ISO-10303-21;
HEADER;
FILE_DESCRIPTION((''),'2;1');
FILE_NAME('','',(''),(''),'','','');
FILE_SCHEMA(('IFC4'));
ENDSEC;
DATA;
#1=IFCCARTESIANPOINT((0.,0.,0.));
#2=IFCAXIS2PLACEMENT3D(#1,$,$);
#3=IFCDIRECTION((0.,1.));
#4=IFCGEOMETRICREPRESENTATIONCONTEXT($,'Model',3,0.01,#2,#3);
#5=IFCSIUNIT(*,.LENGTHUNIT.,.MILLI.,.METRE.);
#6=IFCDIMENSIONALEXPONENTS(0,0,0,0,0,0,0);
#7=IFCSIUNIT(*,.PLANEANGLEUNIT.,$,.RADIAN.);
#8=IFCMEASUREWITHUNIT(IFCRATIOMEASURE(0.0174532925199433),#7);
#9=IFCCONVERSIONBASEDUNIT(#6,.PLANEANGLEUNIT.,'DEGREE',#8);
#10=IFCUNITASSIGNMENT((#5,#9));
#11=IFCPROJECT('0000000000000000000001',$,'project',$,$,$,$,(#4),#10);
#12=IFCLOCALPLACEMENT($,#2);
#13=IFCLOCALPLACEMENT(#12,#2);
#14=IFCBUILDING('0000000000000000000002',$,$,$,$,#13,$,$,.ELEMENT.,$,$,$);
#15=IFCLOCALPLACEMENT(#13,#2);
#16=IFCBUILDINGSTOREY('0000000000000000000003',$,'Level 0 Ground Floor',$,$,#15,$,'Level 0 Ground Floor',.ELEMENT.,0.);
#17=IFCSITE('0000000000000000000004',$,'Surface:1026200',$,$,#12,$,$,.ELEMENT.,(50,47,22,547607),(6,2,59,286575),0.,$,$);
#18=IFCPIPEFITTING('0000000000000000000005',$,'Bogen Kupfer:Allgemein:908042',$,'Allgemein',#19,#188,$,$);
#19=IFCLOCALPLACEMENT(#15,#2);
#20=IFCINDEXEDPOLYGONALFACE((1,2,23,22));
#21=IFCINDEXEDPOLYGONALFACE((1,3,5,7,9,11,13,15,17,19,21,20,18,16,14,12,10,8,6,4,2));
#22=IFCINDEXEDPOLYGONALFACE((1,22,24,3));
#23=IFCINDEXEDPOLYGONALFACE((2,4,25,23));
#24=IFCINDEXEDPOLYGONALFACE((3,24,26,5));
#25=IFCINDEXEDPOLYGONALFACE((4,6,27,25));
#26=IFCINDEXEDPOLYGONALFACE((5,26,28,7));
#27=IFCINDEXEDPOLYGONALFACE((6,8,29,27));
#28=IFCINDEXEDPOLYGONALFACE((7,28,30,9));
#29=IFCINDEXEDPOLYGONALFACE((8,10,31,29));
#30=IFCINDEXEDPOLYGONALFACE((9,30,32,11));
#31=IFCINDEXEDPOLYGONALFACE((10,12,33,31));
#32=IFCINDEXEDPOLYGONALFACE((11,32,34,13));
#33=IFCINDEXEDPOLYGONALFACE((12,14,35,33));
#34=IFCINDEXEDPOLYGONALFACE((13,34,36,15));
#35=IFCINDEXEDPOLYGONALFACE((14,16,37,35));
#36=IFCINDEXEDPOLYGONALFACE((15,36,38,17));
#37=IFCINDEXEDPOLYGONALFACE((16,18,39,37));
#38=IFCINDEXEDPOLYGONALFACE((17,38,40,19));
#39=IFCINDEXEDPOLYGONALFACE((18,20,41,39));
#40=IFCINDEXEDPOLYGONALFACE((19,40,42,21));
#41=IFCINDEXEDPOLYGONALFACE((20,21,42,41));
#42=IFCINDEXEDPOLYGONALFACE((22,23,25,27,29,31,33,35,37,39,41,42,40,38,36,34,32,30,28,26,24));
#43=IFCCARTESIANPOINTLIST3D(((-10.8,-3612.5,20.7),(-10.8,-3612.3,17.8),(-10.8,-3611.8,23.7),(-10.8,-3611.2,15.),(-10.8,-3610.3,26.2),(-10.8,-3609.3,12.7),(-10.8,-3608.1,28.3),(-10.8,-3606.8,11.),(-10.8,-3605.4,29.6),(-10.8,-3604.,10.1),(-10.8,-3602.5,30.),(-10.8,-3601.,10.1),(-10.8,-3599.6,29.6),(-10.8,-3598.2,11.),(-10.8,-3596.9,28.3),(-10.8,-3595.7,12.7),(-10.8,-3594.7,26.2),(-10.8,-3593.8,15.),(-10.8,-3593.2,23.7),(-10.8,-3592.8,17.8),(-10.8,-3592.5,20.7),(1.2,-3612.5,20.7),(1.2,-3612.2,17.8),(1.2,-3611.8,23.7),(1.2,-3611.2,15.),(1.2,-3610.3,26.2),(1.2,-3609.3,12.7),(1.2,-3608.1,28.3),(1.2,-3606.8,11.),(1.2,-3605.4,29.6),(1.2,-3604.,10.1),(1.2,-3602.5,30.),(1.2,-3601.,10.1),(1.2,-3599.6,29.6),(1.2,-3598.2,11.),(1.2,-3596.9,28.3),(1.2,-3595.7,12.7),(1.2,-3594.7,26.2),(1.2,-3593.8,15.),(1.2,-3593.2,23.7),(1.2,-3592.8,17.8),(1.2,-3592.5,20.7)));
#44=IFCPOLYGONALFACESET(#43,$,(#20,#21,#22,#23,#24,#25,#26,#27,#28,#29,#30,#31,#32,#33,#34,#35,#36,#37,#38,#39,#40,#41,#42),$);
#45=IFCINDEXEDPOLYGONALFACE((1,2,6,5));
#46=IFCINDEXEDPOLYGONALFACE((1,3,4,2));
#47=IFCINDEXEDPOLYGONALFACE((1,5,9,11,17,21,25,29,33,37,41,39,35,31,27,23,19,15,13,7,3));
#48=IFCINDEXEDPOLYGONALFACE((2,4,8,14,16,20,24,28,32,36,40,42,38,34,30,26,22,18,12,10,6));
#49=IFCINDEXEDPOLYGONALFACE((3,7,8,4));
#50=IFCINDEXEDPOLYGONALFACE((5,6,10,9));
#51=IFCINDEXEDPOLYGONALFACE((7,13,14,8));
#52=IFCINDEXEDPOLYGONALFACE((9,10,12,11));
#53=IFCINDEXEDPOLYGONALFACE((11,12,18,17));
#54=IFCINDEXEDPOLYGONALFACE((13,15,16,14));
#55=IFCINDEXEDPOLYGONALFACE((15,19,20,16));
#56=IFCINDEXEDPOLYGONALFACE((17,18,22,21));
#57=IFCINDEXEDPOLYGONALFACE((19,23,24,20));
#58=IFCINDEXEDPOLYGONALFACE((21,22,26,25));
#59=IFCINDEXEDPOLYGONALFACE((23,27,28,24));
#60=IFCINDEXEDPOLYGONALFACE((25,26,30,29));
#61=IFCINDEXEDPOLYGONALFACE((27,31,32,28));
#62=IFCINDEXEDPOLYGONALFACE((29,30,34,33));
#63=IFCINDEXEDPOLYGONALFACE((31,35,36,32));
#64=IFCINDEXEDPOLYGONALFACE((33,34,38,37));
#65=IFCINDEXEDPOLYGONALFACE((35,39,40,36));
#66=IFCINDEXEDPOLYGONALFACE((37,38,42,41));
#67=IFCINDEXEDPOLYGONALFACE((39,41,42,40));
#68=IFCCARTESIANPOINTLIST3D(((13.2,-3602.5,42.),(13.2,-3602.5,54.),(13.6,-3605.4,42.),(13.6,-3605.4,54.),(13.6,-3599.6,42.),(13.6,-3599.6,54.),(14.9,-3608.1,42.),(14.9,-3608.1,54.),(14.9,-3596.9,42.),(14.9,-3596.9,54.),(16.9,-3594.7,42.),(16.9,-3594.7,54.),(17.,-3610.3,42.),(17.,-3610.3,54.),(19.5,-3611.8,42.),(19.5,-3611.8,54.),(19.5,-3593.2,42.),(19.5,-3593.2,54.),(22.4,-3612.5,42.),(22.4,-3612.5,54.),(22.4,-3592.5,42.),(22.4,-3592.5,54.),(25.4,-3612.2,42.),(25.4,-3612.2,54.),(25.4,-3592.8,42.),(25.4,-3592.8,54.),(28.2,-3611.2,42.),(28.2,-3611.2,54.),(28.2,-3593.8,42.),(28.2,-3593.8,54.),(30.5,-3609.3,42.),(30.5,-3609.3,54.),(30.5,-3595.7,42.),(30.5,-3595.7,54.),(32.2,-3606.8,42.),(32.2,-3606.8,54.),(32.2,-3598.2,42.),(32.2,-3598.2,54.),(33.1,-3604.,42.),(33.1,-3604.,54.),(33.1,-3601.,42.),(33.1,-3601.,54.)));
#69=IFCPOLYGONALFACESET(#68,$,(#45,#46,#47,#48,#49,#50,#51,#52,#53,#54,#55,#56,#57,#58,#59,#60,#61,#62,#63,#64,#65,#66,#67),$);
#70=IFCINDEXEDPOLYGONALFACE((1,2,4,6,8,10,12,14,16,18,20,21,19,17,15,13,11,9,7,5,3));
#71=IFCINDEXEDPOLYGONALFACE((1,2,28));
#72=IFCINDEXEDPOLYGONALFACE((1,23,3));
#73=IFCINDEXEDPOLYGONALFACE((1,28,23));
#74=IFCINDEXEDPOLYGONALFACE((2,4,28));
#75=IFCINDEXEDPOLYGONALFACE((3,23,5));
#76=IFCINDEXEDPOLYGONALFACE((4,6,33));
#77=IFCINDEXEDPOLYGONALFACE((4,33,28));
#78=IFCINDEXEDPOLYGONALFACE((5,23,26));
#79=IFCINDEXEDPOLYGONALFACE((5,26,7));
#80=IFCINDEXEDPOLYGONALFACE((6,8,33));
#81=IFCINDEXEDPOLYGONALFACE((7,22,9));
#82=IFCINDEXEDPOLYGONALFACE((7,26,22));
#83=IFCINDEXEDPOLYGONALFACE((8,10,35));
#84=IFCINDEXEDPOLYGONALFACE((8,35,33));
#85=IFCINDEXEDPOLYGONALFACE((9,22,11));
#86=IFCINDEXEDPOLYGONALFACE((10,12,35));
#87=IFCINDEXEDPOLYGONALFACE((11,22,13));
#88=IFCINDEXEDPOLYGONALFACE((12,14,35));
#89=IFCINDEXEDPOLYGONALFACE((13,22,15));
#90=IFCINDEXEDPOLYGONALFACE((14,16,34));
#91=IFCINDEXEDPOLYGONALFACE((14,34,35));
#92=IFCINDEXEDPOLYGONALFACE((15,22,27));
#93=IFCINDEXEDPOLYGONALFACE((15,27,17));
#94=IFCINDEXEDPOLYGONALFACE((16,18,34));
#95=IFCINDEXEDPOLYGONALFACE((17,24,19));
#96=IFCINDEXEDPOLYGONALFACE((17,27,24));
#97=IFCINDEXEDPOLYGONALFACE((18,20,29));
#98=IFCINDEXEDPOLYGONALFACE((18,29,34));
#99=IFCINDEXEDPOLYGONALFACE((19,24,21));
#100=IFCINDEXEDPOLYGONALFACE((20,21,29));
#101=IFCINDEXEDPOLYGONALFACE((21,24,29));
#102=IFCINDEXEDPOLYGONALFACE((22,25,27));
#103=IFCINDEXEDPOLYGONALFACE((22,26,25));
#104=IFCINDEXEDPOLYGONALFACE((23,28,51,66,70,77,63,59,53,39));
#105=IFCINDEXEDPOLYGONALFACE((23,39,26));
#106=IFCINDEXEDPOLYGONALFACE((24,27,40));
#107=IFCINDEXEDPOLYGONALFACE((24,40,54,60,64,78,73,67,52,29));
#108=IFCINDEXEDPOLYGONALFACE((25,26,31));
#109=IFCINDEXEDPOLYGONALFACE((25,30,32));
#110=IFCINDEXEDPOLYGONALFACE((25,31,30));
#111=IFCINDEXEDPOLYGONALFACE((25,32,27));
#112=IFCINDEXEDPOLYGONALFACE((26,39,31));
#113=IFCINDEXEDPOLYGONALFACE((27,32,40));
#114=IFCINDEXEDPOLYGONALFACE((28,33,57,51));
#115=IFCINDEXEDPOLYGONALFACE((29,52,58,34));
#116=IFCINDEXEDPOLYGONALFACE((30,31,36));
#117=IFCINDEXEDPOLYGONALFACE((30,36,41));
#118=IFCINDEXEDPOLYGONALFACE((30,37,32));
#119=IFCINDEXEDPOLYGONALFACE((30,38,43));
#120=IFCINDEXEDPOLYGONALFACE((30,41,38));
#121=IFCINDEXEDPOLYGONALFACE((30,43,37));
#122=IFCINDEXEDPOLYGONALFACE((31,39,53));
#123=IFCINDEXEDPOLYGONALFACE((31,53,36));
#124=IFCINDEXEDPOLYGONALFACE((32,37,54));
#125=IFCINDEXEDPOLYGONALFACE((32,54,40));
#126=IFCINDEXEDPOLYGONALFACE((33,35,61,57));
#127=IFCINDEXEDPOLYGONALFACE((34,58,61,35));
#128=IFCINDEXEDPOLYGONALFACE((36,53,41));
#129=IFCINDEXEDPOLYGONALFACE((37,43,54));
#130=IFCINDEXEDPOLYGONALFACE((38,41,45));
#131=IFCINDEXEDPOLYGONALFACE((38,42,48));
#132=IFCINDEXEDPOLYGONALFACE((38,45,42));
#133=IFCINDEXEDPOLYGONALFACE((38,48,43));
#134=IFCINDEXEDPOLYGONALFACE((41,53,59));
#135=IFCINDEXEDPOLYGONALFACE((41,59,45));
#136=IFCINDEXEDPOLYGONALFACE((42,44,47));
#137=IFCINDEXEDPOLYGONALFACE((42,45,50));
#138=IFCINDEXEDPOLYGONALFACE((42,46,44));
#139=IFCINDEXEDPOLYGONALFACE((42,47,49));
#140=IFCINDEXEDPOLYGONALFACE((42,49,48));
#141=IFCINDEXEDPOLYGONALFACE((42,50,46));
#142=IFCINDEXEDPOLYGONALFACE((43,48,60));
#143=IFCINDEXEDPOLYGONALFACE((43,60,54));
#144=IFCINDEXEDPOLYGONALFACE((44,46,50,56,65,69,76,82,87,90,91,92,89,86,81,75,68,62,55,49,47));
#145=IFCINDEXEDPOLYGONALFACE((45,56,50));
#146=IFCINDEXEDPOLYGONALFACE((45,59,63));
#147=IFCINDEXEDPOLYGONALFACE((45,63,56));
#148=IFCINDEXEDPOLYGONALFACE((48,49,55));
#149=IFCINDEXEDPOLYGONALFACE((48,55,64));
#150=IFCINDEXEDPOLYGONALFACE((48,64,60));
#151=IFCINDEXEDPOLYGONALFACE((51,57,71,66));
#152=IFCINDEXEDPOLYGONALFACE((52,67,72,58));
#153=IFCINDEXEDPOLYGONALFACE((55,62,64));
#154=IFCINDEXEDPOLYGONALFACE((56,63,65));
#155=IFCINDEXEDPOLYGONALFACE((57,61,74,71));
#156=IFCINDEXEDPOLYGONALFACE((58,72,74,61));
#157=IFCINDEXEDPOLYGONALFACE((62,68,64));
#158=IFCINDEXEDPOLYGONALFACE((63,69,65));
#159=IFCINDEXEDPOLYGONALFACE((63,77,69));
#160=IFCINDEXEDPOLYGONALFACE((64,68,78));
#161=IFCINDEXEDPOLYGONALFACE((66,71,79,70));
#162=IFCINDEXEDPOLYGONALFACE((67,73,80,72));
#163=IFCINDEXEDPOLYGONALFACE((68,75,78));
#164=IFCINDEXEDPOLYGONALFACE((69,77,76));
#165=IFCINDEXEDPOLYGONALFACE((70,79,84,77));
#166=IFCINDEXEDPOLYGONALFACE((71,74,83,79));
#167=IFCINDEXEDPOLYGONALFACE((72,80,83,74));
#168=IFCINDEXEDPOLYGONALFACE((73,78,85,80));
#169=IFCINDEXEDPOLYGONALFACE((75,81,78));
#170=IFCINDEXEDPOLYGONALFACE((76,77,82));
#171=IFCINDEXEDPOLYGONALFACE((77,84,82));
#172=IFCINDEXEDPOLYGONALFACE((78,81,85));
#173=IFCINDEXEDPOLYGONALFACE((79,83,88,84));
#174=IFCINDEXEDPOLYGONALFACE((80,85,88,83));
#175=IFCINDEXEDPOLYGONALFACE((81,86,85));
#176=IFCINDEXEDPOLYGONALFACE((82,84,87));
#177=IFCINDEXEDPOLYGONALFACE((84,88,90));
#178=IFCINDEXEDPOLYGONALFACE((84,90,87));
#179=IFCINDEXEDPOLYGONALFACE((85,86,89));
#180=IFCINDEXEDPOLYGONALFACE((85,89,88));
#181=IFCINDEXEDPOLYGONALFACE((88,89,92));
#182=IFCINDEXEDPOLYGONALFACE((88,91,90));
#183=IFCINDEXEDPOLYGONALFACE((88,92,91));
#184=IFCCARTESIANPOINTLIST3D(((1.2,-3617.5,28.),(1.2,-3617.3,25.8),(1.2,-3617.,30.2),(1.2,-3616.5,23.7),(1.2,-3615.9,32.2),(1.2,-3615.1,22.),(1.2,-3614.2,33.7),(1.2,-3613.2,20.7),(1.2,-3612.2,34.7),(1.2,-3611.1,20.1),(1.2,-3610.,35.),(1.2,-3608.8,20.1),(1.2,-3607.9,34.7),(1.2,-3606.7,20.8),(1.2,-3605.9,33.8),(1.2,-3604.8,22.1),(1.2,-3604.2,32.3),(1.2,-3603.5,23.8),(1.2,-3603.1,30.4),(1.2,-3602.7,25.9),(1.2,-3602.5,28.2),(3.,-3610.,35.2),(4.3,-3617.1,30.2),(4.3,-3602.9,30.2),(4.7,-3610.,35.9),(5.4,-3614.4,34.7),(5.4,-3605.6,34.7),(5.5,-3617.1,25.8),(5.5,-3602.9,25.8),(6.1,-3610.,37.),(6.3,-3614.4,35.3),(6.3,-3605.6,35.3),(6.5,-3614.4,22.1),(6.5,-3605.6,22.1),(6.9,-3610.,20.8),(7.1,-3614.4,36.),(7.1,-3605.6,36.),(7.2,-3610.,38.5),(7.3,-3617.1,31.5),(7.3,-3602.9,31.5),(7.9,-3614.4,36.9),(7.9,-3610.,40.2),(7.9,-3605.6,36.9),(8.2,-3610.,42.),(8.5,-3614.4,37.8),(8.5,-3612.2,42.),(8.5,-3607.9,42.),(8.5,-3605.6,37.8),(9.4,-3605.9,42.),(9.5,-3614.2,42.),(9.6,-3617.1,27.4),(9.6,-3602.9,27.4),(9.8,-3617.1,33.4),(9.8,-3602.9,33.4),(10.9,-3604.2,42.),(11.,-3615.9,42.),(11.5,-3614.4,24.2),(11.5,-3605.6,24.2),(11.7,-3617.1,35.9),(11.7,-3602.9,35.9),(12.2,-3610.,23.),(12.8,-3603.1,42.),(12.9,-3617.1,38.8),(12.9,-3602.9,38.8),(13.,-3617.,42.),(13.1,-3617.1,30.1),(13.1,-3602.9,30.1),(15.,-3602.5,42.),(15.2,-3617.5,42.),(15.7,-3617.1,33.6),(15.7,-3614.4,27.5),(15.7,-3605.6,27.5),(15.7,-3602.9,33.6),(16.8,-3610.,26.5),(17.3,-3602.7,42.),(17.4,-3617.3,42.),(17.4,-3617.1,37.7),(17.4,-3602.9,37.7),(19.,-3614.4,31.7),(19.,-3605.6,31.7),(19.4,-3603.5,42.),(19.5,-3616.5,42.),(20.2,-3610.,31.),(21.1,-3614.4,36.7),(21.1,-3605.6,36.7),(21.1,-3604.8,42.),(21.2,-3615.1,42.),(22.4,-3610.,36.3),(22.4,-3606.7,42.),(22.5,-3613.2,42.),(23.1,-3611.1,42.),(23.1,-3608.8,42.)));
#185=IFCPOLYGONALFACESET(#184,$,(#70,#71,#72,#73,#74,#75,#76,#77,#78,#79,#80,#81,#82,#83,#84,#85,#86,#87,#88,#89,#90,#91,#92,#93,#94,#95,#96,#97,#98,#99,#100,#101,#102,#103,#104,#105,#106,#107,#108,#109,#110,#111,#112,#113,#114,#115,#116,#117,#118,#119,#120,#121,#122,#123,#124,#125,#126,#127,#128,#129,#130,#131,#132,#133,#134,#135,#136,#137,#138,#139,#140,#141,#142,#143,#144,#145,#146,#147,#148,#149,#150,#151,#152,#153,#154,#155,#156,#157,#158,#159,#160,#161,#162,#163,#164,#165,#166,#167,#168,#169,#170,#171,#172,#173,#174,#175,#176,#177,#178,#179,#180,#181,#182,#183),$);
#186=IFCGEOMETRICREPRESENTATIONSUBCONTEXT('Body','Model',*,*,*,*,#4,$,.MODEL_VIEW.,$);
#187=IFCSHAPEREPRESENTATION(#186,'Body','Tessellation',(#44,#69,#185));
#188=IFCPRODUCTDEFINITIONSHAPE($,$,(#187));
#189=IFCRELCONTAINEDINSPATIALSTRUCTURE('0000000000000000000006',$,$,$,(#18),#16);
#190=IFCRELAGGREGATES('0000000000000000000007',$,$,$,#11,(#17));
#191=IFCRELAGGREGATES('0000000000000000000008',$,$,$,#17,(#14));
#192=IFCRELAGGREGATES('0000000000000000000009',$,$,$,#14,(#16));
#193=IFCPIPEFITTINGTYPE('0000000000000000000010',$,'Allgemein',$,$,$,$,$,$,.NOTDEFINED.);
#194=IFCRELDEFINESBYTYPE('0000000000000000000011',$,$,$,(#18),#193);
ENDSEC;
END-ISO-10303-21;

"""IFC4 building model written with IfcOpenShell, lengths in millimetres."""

from ifc_helpers import new_model, entity, si_unit, converted_unit, direction, frame, frame_2d, origin, place, context, subcontext, project, spatial, circle, extrude, source, transform, mapped, type_object, type_shapes, element, save


model = new_model("IFC4")

# Units and contexts
model_context = context("Model", 3, precision=0.01, world=origin(), true_north=direction((0.0, 1.0)))
body_context = subcontext(model_context, "Body", "Model", "MODEL_VIEW")
ifc_project = project(units=[si_unit("LENGTHUNIT", "METRE", prefix="MILLI"), converted_unit("PLANEANGLEUNIT", "DEGREE", entity("IfcRatioMeasure", 0.0174532925199433), si_unit("PLANEANGLEUNIT", "RADIAN"), dimensions=[0, 0, 0, 0, 0, 0, 0])], contexts=[model_context])

# Site, building, storey
site_placement = place(None, origin())
site = spatial("IfcSite", under=ifc_project, at=site_placement, Name="Surface:1026200", CompositionType="ELEMENT", RefLatitude=(50, 47, 22, 547607), RefLongitude=(6, 2, 59, 286575), RefElevation=0.0)
building_placement = place(site_placement, origin())
building = spatial("IfcBuilding", under=site, at=building_placement, CompositionType="ELEMENT")
storey_placement = place(building_placement, origin())
storey = spatial("IfcBuildingStorey", under=building, at=storey_placement, Name="Level 0 Ground Floor", LongName="Level 0 Ground Floor", CompositionType="ELEMENT", Elevation=0.0)

# Pipe fitting
pipe_fitting_type = type_object("IfcPipeFittingType", Name="Allgemein", PredefinedType="NOTDEFINED")
ifc_direction = entity("IfcDirection", [0.0, 0.0, -1.0])
trimmed_curve = entity("IfcTrimmedCurve", entity("IfcCircle", entity("IfcAxis2Placement2D", entity("IfcCartesianPoint", [-14.5, 0.0]), entity("IfcDirection", [0.0, 1.0])), 14.5), [entity("IfcParameterValue", 270.0)], [entity("IfcParameterValue", 0.0)], True, "PARAMETER")
shared_shape_1 = source(origin(), body_context, "Body", "SolidModel", [
    extrude(circle(Radius=10.0, at=frame_2d((0.0, 0.0), x_axis=(1.0, 0.0))), frame((0.0, 22.0, 0.0), z_axis=(0.0, 1.0, 0.0), x_axis=(-1.0, 0.0, 0.0)), (0.0, 0.0, 1.0), 12.0),
    extrude(circle(Radius=10.0, at=frame_2d((0.0, 0.0), x_axis=(1.0, 0.0))), frame((-34.0, 0.0, 0.0), z_axis=(1.0, 0.0, 0.0), x_axis=(0.0, 1.0, 0.0)), (0.0, 0.0, 1.0), 12.0),
    entity("IfcSurfaceCurveSweptAreaSolid", entity("IfcCircleProfileDef", "AREA", None, entity("IfcAxis2Placement2D", entity("IfcCartesianPoint", [0.0, 7.5]), entity("IfcDirection", [1.0, 0.0])), 7.5), entity("IfcAxis2Placement3D", entity("IfcCartesianPoint", [-7.5, 22.0, 0.0]), ifc_direction, entity("IfcDirection", [1.0, 0.0, 0.0])), trimmed_curve, 0.0, 90.0, entity("IfcSurfaceOfLinearExtrusion", entity("IfcArbitraryOpenProfileDef", "CURVE", None, trimmed_curve), entity("IfcAxis2Placement3D", entity("IfcCartesianPoint", [0.0, 0.0, -304.8])), ifc_direction, 1.0)),
])
type_shapes(pipe_fitting_type, [shared_shape_1])
for number, where, z_axis, x_axis, name in (
    (1, (23.2, -3602.5, 20.0), (-0.000017, 1.0, 0.0), (0.0, 0.0, -1.0), "Bogen Kupfer:Allgemein:908042"),
):
    element("IfcPipeFitting", number, at=place(storey_placement, frame(where, z_axis=z_axis, x_axis=x_axis)), inside=storey, type_object=pipe_fitting_type, Name=name, ObjectType="Allgemein", context=body_context, shape_type="MappedRepresentation", body=[
        mapped(shared_shape_1, transform((0.0, 0.0, 0.0), scale=1.0)),
    ])

save(model, "model.ifc")
